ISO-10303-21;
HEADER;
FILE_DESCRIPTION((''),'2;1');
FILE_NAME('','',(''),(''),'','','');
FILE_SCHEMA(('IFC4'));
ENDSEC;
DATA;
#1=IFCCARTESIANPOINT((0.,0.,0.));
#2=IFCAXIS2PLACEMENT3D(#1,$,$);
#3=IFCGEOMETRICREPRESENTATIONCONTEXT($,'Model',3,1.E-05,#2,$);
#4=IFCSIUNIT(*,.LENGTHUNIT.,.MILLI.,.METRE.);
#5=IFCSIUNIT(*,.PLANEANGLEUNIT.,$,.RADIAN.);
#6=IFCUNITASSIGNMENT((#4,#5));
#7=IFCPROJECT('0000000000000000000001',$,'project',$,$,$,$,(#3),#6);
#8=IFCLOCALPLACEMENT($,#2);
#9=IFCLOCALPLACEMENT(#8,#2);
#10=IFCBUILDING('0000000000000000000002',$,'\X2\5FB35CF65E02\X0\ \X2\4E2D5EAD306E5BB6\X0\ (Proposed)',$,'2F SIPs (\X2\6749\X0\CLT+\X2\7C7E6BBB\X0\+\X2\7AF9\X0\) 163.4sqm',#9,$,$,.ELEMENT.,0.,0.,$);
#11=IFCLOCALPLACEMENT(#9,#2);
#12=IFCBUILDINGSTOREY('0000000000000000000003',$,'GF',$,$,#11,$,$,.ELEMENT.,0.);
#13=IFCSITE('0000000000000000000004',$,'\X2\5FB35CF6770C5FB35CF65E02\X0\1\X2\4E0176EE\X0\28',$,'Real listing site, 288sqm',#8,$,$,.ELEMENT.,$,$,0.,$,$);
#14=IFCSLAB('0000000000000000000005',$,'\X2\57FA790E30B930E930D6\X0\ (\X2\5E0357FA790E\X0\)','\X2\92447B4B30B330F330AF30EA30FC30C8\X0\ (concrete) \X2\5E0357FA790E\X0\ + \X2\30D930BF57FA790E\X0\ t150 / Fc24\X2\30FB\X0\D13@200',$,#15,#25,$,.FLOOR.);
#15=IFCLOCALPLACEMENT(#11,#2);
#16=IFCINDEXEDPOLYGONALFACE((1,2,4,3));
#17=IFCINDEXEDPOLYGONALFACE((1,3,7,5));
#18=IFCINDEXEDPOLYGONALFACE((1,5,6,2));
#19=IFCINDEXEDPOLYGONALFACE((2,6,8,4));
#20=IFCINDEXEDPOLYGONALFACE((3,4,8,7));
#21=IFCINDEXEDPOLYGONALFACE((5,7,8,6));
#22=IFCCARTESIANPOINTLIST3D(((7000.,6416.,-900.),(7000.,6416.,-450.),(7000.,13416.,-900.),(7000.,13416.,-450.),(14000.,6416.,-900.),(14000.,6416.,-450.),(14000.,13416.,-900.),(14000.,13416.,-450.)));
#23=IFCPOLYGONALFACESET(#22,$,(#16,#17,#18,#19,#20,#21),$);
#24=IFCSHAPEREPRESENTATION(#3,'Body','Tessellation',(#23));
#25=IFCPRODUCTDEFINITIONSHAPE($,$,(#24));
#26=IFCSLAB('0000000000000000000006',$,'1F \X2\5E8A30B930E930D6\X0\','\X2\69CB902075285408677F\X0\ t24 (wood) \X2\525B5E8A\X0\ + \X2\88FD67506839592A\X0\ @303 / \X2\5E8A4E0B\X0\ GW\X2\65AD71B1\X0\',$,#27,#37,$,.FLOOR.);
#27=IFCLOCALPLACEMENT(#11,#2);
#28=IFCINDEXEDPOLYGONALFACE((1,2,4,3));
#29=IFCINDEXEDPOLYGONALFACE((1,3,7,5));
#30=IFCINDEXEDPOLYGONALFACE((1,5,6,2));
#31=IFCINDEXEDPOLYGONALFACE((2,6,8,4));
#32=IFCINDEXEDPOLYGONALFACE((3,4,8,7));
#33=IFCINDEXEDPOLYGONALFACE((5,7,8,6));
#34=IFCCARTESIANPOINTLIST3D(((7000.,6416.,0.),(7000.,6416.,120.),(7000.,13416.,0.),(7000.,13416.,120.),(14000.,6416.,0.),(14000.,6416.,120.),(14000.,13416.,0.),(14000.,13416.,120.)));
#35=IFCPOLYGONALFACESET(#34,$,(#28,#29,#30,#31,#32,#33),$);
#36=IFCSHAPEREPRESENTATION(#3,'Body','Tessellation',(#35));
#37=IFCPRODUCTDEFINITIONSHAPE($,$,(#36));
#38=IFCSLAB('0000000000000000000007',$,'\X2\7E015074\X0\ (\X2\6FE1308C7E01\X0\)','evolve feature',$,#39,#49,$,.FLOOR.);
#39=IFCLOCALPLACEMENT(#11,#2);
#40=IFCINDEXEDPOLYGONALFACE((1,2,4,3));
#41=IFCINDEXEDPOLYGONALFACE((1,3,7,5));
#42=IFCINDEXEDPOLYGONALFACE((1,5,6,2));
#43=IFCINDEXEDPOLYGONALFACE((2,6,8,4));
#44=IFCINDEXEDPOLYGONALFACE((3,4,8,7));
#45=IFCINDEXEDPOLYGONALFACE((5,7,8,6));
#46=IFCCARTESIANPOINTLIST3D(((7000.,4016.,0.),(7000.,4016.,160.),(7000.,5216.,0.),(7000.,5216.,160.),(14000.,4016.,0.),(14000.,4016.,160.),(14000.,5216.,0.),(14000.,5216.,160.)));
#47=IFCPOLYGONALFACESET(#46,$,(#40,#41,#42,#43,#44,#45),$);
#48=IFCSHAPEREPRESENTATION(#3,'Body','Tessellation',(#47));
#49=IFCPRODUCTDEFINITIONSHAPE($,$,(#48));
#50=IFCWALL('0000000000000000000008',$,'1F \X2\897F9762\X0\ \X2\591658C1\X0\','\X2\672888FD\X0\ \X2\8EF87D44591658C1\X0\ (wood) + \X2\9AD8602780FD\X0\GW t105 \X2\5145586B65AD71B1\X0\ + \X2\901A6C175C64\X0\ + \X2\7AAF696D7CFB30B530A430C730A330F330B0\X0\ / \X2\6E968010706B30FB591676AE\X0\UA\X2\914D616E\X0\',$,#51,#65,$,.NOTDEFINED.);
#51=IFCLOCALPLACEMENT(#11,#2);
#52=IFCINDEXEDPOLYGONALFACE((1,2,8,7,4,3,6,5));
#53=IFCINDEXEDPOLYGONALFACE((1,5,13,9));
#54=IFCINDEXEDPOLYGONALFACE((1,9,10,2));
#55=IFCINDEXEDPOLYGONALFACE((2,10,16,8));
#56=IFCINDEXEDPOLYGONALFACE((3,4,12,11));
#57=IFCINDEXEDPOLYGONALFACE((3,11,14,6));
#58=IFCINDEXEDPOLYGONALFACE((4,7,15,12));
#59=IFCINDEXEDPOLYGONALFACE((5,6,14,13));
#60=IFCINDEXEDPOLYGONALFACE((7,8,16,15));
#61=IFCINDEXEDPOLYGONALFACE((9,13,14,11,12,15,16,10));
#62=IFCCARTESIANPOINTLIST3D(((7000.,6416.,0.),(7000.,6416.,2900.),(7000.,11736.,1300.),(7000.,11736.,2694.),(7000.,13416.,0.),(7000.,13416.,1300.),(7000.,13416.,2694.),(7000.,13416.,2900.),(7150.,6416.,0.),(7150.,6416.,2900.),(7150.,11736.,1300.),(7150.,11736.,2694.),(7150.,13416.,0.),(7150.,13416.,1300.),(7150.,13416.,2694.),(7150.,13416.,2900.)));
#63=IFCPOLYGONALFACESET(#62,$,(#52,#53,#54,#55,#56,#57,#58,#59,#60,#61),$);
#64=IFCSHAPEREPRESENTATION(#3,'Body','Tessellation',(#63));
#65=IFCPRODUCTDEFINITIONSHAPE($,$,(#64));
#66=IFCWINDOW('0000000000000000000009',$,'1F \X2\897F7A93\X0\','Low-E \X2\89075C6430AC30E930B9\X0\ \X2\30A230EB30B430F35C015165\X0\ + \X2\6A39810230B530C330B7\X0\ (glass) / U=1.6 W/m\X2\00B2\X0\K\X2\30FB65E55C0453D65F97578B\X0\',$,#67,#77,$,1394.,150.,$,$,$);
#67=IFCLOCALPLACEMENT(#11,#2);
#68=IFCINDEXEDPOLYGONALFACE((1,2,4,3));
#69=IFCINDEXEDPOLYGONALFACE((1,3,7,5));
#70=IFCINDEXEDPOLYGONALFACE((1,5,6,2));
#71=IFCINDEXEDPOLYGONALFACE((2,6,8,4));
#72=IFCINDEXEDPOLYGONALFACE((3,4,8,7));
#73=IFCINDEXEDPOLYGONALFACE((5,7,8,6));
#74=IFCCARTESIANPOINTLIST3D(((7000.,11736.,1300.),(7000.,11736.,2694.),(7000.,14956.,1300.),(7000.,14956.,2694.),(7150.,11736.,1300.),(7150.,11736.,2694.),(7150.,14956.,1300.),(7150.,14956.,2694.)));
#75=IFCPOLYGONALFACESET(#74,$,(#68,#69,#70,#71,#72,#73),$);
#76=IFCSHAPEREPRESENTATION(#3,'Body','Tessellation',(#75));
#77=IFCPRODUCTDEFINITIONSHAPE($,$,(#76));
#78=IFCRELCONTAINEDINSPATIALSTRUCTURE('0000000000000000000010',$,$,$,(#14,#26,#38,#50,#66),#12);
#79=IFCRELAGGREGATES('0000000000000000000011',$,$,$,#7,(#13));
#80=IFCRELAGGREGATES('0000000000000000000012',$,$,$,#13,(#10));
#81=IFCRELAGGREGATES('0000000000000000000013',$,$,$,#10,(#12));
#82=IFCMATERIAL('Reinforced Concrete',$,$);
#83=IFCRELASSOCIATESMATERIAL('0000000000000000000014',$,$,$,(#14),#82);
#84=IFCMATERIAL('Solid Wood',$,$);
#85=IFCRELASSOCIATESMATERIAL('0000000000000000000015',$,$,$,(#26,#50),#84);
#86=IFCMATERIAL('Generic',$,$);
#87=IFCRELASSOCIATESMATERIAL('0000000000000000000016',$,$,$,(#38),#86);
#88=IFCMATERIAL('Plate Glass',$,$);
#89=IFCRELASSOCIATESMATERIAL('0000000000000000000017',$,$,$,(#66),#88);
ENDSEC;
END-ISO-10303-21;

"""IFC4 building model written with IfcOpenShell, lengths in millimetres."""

from ifc_helpers import new_model, si_unit, frame, frame_2d, origin, place, context, project, spatial, rectangle, extrude, material, element, fill, save


model = new_model("IFC4")

# Units and contexts
model_context = context("Model", 3, precision=1e-05, world=origin())
ifc_project = project(units=[si_unit("LENGTHUNIT", "METRE", prefix="MILLI"), si_unit("PLANEANGLEUNIT", "RADIAN")], contexts=[model_context])

# Site, building, storey
site_placement = place(None, origin())
site = spatial("IfcSite", under=ifc_project, at=site_placement, Name="徳島県徳島市1丁目28", ObjectType="Real listing site, 288sqm", CompositionType="ELEMENT", RefElevation=0.0)
building_placement = place(site_placement, origin())
building = spatial("IfcBuilding", under=site, at=building_placement, Name="徳島市 中庭の家 (Proposed)", ObjectType="2F SIPs (杉CLT+籾殻+竹) 163.4sqm", CompositionType="ELEMENT", ElevationOfRefHeight=0.0, ElevationOfTerrain=0.0)
storey_placement = place(building_placement, origin())
storey = spatial("IfcBuildingStorey", under=building, at=storey_placement, Name="GF", CompositionType="ELEMENT", Elevation=0.0)

# Slabs
ifc_material_1 = material(Name="Reinforced Concrete")
slab_1_placement = place(storey_placement, frame((3500.0, 3208.0, -450.0)))
element("IfcSlab", 1, at=slab_1_placement, inside=storey, material=ifc_material_1, Name="基礎スラブ (布基礎)", Description="鉄筋コンクリート (concrete) 布基礎 + ベタ基礎 t150 / Fc24・D13@200", PredefinedType="FLOOR", context=model_context, shape_type="SweptSolid", body=[
    extrude(rectangle(XDim=7000.0, YDim=7000.0, at=frame_2d((3500.0, 3500.0))), frame((3500.0, 3208.0, -450.0)), (0.0, 0.0, 1.0), 450.0),
])
ifc_material_2 = material(Name="Solid Wood")
slab_2_placement = place(storey_placement, frame((3500.0, 3208.0, 0.0)))
element("IfcSlab", 2, at=slab_2_placement, inside=storey, material=ifc_material_2, Name="1F 床スラブ", Description="構造用合板 t24 (wood) 剛床 + 製材根太 @303 / 床下 GW断熱", PredefinedType="FLOOR", context=model_context, shape_type="SweptSolid", body=[
    extrude(rectangle(XDim=7000.0, YDim=7000.0, at=frame_2d((3500.0, 3500.0))), frame((3500.0, 3208.0, 0.0)), (0.0, 0.0, 1.0), 120.0),
])
ifc_material_3 = material(Name="Generic")
slab_3_placement = place(storey_placement, frame((3500.0, 2008.0, 0.0)))
element("IfcSlab", 3, at=slab_3_placement, inside=storey, material=ifc_material_3, Name="縁側 (濡れ縁)", Description="evolve feature", PredefinedType="FLOOR", context=model_context, shape_type="SweptSolid", body=[
    extrude(rectangle(XDim=7000.0, YDim=1200.0, at=frame_2d((3500.0, 600.0))), frame((3500.0, 2008.0, 0.0)), (0.0, 0.0, 1.0), 160.0),
])

# Shared definitions
ifc_material_4 = material(Name="Plate Glass")

# Wall, opening, window
wall_1_placement = place(storey_placement, frame((3500.0, 3208.0, 0.0)))
wall_1 = element("IfcWall", 4, at=wall_1_placement, inside=storey, material=ifc_material_2, Name="1F 西面 外壁", Description="木製 軸組外壁 (wood) + 高性能GW t105 充填断熱 + 通気層 + 窯業系サイディング / 準耐火・外皮UA配慮", PredefinedType="NOTDEFINED", context=model_context, shape_type="SweptSolid", body=[
    extrude(rectangle(XDim=150.0, YDim=7000.0, at=frame_2d((75.0, 3500.0))), frame((3500.0, 3208.0, 0.0)), (0.0, 0.0, 1.0), 2900.0),
])
opening_1_placement = place(storey_placement, frame((3500.0, 5868.0, 650.0)))
opening_1 = element("IfcOpeningElement", 5, at=opening_1_placement, cuts=wall_1, PredefinedType="NOTDEFINED", context=model_context, shape_type="SweptSolid", body=[
    extrude(rectangle(XDim=150.0, YDim=3220.0, at=frame_2d((75.0, 1610.0))), frame((3500.0, 5868.0, 650.0)), (0.0, 0.0, 1.0), 1394.0),
])
window_1_placement = place(storey_placement, frame((3500.0, 5868.0, 650.0)))
window_1 = element("IfcWindow", 6, at=window_1_placement, inside=storey, material=ifc_material_4, Name="1F 西窓", Description="Low-E 複層ガラス アルゴン封入 + 樹脂サッシ (glass) / U=1.6 W/m²K・日射取得型", OverallHeight=1394.0, OverallWidth=150.0, context=model_context, shape_type="SweptSolid", body=[
    extrude(rectangle(XDim=150.0, YDim=3220.0, at=frame_2d((75.0, 1610.0))), frame((3500.0, 5868.0, 650.0)), (0.0, 0.0, 1.0), 1394.0),
])
fill(opening_1, window_1)

save(model, "model.ifc")
